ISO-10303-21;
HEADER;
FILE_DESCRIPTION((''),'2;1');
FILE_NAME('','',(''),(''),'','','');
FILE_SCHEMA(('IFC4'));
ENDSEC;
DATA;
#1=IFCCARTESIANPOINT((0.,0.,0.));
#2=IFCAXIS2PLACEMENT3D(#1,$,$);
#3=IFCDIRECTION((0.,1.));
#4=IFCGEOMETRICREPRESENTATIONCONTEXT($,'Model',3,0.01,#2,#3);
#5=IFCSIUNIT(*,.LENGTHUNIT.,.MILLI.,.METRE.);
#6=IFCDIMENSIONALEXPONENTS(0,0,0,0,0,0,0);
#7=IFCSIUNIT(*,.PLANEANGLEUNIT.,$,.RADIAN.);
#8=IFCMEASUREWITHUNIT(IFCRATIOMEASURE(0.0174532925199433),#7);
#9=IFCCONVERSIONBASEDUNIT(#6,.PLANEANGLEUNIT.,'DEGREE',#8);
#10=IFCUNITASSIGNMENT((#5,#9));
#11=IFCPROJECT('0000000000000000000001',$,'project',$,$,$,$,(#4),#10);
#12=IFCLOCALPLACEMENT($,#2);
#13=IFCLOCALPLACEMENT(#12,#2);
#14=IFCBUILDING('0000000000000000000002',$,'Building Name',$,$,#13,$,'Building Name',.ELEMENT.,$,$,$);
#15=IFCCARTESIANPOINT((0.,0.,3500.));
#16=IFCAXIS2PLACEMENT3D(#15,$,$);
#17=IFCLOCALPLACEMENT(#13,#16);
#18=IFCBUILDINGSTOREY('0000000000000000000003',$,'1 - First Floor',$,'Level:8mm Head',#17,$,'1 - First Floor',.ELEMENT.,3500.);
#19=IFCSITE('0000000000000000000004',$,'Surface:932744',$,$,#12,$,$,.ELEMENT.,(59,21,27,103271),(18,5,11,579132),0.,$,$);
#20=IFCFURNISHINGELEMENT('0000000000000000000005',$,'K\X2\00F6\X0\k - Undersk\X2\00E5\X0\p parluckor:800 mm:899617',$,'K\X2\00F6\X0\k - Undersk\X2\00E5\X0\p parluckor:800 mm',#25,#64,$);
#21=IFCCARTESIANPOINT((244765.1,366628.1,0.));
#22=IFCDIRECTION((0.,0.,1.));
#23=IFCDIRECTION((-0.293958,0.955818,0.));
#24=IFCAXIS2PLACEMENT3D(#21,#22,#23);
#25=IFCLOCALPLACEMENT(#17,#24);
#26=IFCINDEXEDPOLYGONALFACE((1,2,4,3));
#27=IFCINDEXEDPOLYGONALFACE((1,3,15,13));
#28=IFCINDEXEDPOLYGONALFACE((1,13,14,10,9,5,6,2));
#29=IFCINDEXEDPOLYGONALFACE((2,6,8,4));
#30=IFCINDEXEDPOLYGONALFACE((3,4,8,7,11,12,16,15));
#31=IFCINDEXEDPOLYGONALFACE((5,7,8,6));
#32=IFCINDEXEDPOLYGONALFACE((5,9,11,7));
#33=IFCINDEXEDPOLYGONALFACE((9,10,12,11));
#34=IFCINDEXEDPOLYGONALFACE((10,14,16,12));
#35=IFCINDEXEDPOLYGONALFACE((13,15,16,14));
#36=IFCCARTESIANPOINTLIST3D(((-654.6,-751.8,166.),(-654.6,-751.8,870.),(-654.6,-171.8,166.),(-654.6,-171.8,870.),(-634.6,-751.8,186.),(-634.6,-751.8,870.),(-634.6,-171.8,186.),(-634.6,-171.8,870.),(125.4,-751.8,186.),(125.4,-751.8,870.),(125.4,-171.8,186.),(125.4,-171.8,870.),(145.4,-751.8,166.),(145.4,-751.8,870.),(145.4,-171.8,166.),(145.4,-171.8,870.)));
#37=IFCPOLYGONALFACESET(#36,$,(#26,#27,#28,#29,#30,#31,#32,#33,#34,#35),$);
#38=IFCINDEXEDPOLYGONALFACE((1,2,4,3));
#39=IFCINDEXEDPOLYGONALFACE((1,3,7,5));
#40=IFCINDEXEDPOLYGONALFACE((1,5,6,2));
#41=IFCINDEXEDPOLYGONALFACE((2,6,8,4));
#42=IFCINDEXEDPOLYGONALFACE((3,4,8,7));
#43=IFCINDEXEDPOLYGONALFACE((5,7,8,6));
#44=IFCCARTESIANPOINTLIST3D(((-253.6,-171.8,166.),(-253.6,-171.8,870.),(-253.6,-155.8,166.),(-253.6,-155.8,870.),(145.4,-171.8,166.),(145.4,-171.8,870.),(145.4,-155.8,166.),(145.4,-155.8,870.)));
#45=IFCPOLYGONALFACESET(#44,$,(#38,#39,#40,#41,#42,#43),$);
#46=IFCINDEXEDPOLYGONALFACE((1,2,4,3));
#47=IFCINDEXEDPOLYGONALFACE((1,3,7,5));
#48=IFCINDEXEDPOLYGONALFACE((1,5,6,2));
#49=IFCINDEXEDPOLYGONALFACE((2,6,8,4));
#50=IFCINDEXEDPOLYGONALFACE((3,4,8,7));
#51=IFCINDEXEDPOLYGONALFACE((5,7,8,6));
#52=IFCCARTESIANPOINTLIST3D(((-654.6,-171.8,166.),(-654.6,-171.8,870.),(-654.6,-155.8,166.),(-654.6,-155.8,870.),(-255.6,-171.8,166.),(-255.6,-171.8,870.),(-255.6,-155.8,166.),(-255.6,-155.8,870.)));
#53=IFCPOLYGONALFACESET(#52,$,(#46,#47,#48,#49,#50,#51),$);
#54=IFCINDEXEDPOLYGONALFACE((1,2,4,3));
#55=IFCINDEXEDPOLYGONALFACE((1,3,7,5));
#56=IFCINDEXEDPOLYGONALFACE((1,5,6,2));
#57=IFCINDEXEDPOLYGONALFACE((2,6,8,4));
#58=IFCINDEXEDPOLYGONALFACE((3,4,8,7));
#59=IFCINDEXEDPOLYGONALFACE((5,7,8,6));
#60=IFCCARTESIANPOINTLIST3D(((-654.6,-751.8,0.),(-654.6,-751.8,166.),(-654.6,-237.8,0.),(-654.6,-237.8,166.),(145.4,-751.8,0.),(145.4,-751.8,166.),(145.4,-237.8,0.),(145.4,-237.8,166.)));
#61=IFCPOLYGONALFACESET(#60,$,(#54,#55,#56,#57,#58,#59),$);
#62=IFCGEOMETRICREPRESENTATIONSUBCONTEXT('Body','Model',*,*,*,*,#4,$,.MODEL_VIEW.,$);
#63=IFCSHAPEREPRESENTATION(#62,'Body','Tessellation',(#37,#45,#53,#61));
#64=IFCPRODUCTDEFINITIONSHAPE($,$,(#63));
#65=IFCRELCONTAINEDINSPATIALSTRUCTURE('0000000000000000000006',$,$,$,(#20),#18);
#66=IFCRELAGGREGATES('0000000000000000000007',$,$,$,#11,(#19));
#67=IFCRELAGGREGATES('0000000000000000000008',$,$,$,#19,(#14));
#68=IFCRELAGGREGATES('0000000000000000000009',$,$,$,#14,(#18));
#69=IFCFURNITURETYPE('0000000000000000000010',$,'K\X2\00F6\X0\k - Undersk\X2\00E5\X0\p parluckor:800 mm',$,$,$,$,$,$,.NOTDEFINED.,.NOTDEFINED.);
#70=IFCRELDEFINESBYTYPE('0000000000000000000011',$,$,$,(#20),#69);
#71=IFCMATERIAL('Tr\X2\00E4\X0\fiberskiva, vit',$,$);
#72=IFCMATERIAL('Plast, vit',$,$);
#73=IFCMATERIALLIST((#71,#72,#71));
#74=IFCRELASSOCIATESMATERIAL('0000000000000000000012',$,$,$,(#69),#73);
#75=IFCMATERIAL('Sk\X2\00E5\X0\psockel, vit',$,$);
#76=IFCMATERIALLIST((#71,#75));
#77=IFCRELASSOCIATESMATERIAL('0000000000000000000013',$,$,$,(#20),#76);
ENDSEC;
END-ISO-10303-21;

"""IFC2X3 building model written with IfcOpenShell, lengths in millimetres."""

from ifc_helpers import new_model, entity, si_unit, converted_unit, direction, frame, frame_2d, origin, origin_2d_with_axis, place, context, subcontext, project, spatial, polyline, rectangle, outline, extrude, source, transform, mapped, material, material_list, type_object, type_shapes, element, save


model = new_model("IFC2X3")

# Units and contexts
model_context = context("Model", 3, precision=0.01, world=origin(), true_north=direction((0.0, 1.0)))
body_context = subcontext(model_context, "Body", "Model", "MODEL_VIEW")
ifc_project = project(units=[si_unit("LENGTHUNIT", "METRE", prefix="MILLI"), converted_unit("PLANEANGLEUNIT", "DEGREE", entity("IfcRatioMeasure", 0.0174532925199433), si_unit("PLANEANGLEUNIT", "RADIAN"), dimensions=[0, 0, 0, 0, 0, 0, 0])], contexts=[model_context])

# Site, building, storey
site_placement = place(None, origin())
site = spatial("IfcSite", under=ifc_project, at=site_placement, Name="Surface:932744", CompositionType="ELEMENT", RefLatitude=(59, 21, 27, 103271), RefLongitude=(18, 5, 11, 579132), RefElevation=0.0)
building_placement = place(site_placement, origin())
building = spatial("IfcBuilding", under=site, at=building_placement, Name="Building Name", LongName="Building Name", CompositionType="ELEMENT")
storey_placement = place(building_placement, frame((0.0, 0.0, 3500.0)))
storey = spatial("IfcBuildingStorey", under=building, at=storey_placement, Name="1 - First Floor", ObjectType="Level:8mm Head", LongName="1 - First Floor", CompositionType="ELEMENT", Elevation=3500.0)

# Furnishing element
ifc_material_1 = material(Name="Träfiberskiva, vit")
ifc_material_2 = material(Name="Skåpsockel, vit")
ifc_material_3 = material(Name="Plast, vit")
ifc_material_list_1 = material_list([ifc_material_1, ifc_material_2])
ifc_material_list_2 = material_list([ifc_material_1, ifc_material_3, ifc_material_1])
furniture_type_1 = type_object("IfcFurnitureType", Name="Kök - Underskåp parluckor:800 mm", material=ifc_material_list_2)
shared_shape_1 = source(origin(), body_context, "Body", "SweptSolid", [
    extrude(outline(polyline([(-400.0, -347.0), (-380.0, -347.0), (-380.0, 337.0), (380.0, 337.0), (380.0, -347.0), (400.0, -347.0), (400.0, 357.0), (-400.0, 357.0), (-400.0, -347.0)])), frame((-254.6, -751.8, 523.0), z_axis=(0.0, 1.0, 0.0), x_axis=(1.0, 0.0, 0.0)), (0.0, 0.0, 1.0), 580.0),
    extrude(rectangle(XDim=399.0, YDim=16.0, at=frame_2d((0.0, 0.0), x_axis=(1.0, 0.0))), frame((-54.1, -163.8, 166.0), z_axis=(0.0, 0.0, 1.0), x_axis=(-1.0, 0.0, 0.0)), (0.0, 0.0, 1.0), 704.0),
    extrude(rectangle(XDim=399.0, YDim=16.0, at=frame_2d((0.0, 0.0), x_axis=(1.0, 0.0))), frame((-455.1, -163.8, 166.0), z_axis=(0.0, 0.0, 1.0), x_axis=(-1.0, 0.0, 0.0)), (0.0, 0.0, 1.0), 704.0),
    extrude(rectangle(XDim=514.0, YDim=800.0, at=origin_2d_with_axis()), frame((-254.6, -494.8, 0.0), z_axis=(0.0, 0.0, 1.0), x_axis=(0.0, 1.0, 0.0)), (0.0, 0.0, 1.0), 166.0),
])
type_shapes(furniture_type_1, [shared_shape_1])
furnishing_1_placement = place(storey_placement, frame((244765.1, 366628.1, 0.0), z_axis=(0.0, 0.0, 1.0), x_axis=(-0.293958, 0.955818, 0.0)))
element("IfcFurnishingElement", 1, at=furnishing_1_placement, inside=storey, type_object=furniture_type_1, material=ifc_material_list_1, Name="Kök - Underskåp parluckor:800 mm:899617", ObjectType="Kök - Underskåp parluckor:800 mm", context=body_context, shape_type="MappedRepresentation", body=[
    mapped(shared_shape_1, transform((0.0, 0.0, 0.0), scale=1.0)),
])

save(model, "model.ifc")
